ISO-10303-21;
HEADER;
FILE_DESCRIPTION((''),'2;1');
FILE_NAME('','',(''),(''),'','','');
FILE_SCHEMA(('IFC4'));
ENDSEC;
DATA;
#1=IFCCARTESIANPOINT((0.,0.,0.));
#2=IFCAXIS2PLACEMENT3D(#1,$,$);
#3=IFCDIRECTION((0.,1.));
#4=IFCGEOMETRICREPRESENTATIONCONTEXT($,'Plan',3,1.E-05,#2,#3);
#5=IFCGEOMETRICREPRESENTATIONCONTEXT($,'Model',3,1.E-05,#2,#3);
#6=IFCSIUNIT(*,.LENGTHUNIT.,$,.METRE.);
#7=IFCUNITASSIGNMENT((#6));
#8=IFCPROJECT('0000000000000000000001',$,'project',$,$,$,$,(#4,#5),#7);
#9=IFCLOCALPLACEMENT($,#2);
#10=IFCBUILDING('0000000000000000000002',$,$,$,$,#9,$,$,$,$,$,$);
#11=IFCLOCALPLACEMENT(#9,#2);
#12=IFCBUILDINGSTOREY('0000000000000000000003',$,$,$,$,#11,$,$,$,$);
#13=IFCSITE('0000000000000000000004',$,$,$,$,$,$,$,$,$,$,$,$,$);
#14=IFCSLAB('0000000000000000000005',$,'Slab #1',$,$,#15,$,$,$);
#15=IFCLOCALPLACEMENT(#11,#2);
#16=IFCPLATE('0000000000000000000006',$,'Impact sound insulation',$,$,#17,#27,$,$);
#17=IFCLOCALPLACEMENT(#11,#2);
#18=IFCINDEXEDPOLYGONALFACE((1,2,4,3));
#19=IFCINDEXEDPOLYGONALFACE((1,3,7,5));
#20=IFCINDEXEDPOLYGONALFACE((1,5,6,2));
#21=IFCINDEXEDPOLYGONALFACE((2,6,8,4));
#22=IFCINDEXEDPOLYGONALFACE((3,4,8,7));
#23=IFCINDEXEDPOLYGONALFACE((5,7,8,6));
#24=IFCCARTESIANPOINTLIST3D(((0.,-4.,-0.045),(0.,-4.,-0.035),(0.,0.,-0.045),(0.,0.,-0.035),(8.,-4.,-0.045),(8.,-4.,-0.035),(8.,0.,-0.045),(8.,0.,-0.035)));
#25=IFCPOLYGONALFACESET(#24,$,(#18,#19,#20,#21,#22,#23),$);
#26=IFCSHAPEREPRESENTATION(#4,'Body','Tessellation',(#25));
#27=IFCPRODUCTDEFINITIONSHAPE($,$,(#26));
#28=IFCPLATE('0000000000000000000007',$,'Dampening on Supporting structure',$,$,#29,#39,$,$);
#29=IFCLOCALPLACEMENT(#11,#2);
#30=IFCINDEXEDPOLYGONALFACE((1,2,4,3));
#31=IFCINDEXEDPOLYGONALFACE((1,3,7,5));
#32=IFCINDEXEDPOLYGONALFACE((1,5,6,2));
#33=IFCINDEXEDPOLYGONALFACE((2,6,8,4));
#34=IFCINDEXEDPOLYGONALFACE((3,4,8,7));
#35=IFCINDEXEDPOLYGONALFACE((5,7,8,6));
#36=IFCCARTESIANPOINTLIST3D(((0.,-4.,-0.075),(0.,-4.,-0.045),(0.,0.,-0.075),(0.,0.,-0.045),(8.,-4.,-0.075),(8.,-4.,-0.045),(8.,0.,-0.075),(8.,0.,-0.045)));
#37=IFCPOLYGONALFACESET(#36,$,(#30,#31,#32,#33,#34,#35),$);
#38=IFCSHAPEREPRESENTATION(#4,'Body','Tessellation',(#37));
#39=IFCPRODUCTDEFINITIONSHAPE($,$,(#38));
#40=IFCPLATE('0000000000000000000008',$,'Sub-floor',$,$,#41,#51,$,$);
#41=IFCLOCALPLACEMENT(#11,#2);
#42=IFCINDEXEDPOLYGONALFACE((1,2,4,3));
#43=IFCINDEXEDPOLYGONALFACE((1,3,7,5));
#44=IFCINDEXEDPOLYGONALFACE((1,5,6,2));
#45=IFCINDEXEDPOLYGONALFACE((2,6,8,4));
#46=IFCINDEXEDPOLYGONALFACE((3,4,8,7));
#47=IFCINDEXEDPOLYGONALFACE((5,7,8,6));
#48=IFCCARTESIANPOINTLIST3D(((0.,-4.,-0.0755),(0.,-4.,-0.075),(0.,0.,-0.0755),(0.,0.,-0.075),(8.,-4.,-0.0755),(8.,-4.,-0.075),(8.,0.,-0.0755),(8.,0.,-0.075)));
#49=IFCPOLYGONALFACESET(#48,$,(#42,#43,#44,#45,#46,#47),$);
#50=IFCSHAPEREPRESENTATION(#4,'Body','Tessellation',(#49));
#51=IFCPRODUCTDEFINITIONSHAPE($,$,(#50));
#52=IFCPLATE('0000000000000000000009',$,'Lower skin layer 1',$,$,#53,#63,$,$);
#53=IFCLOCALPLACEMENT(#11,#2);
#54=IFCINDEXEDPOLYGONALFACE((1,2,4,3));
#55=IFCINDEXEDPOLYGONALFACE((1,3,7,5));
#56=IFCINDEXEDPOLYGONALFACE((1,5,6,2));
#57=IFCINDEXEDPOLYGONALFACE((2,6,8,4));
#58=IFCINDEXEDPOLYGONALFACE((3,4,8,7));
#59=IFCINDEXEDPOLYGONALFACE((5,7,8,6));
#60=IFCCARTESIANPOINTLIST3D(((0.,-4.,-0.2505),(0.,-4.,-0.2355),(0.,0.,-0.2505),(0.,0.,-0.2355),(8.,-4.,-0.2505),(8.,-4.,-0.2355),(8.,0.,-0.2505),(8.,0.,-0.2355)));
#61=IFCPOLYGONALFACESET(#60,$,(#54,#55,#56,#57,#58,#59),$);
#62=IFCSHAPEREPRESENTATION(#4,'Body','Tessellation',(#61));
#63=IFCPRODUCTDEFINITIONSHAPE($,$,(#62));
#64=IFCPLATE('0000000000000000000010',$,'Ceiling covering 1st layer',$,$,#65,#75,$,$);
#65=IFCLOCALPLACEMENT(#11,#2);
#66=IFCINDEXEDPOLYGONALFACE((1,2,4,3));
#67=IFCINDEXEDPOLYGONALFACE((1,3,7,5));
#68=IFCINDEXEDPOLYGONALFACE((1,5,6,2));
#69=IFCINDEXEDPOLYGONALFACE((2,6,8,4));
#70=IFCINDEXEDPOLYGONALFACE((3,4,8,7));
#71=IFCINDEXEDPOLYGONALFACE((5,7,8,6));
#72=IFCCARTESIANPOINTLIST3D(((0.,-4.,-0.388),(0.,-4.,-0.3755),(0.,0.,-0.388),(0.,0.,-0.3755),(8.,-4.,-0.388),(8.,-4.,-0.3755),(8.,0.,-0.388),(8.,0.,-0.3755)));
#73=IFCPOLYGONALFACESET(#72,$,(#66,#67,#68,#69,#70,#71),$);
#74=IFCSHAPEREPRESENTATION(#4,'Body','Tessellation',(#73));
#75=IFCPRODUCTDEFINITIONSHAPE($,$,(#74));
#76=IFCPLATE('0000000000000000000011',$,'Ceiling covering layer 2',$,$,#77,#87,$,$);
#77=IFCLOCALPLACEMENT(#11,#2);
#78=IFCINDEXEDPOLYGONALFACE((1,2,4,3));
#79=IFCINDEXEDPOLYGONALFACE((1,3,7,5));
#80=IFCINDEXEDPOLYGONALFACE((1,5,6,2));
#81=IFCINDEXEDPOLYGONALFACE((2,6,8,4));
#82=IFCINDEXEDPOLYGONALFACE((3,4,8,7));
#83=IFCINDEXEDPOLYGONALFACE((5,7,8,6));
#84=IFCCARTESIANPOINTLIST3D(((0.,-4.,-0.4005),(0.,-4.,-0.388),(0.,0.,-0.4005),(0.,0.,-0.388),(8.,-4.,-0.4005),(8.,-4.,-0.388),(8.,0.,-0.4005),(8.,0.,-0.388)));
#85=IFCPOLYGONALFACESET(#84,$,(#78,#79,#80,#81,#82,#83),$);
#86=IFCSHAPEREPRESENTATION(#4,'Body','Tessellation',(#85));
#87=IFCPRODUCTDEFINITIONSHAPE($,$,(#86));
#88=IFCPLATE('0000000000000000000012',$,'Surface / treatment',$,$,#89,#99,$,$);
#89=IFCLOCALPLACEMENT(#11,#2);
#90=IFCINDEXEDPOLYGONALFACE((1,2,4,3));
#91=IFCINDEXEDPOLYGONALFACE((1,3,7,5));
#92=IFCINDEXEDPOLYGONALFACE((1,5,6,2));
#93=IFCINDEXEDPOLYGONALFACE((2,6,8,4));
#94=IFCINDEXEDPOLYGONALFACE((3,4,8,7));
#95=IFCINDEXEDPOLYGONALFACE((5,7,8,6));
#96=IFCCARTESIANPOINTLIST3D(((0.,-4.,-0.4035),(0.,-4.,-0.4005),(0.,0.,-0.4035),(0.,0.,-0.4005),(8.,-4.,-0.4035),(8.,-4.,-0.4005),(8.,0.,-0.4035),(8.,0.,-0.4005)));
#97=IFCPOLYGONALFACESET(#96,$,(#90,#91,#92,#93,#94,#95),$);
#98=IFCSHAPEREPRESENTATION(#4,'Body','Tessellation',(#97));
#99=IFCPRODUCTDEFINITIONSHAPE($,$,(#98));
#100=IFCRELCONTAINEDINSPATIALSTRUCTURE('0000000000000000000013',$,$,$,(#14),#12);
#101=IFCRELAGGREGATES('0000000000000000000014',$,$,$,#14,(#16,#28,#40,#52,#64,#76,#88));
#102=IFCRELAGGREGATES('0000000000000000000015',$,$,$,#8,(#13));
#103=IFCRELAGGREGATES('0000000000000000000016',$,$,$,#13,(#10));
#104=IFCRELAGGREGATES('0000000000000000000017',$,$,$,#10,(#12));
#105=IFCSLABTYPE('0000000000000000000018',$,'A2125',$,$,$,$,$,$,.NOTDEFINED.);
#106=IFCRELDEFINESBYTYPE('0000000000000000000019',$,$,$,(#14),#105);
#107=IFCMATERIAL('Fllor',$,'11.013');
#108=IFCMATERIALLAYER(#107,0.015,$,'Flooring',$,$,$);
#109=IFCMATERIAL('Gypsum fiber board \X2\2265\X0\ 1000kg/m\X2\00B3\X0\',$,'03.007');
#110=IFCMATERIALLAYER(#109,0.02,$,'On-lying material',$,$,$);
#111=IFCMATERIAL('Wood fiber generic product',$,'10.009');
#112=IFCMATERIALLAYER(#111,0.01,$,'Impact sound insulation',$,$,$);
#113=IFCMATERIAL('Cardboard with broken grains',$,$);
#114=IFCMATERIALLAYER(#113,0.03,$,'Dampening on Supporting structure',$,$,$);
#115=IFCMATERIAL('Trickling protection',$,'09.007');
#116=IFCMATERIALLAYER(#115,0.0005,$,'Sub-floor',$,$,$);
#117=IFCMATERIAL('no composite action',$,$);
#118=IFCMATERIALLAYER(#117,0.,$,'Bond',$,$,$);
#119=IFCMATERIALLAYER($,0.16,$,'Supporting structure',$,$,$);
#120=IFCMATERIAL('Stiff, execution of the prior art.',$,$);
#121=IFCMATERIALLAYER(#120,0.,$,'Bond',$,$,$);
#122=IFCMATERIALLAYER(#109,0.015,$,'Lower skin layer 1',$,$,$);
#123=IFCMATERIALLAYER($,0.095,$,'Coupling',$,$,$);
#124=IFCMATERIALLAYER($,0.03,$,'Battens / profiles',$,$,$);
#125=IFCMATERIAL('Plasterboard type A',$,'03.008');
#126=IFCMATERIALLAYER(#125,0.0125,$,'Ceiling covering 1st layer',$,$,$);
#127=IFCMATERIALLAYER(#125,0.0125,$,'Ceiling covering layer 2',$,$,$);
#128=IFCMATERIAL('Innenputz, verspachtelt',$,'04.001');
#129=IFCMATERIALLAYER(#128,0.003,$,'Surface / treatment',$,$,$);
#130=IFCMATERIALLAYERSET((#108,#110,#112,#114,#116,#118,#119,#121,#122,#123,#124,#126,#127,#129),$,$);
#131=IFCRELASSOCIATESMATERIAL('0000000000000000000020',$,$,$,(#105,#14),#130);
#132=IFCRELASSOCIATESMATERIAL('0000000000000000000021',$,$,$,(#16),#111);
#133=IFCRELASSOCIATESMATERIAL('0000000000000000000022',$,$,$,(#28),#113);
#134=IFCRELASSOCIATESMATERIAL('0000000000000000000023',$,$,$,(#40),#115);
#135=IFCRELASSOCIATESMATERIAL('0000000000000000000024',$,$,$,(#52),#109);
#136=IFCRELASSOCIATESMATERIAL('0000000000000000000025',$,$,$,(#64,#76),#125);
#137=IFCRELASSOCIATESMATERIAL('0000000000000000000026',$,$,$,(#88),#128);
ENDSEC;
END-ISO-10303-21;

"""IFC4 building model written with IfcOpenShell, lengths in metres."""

from ifc_helpers import new_model, si_unit, direction, frame, frame_2d, origin, place, context, project, spatial, rectangle, extrude, material, layer, layer_set, type_object, element, aggregate, save


model = new_model("IFC4")

# Units and contexts
plan_context = context("Plan", 3, precision=1e-05, world=origin(), true_north=direction((0.0, 1.0)))
model_context = context("Model", 3, precision=1e-05, world=origin(), true_north=direction((0.0, 1.0)))
ifc_project = project(units=[si_unit("LENGTHUNIT", "METRE")], contexts=[plan_context, model_context])

# Site, building, storey
site = spatial("IfcSite", under=ifc_project)
building_placement = place(None, origin())
building = spatial("IfcBuilding", under=site, at=building_placement)
storey_placement = place(building_placement, origin())
storey = spatial("IfcBuildingStorey", under=building, at=storey_placement)

# Slab, plates
ifc_material_1 = material(Name="Fllor", Category="11.013")
ifc_layer_1 = layer(ifc_material_1, 0.015, Name="Flooring")
ifc_material_2 = material(Name="Gypsum fiber board ≥ 1000kg/m³", Category="03.007")
ifc_layer_2 = layer(ifc_material_2, 0.02, Name="On-lying material")
ifc_material_3 = material(Name="Wood fiber generic product", Category="10.009")
ifc_layer_3 = layer(ifc_material_3, 0.01, Name="Impact sound insulation")
ifc_material_4 = material(Name="Cardboard with broken grains")
ifc_layer_4 = layer(ifc_material_4, 0.03, Name="Dampening on Supporting structure")
ifc_material_5 = material(Name="Trickling protection", Category="09.007")
ifc_layer_5 = layer(ifc_material_5, 0.0005, Name="Sub-floor")
ifc_material_6 = material(Name="no composite action")
ifc_layer_6 = layer(ifc_material_6, 0.0, Name="Bond")
ifc_layer_7 = layer(None, 0.16, Name="Supporting structure")
ifc_material_7 = material(Name="Stiff, execution of the prior art.")
ifc_layer_8 = layer(ifc_material_7, 0.0, Name="Bond")
ifc_layer_9 = layer(ifc_material_2, 0.015, Name="Lower skin layer 1")
ifc_layer_10 = layer(None, 0.095, Name="Coupling")
ifc_layer_11 = layer(None, 0.03, Name="Battens / profiles")
ifc_material_8 = material(Name="Plasterboard type A", Category="03.008")
ifc_layer_12 = layer(ifc_material_8, 0.0125, Name="Ceiling covering 1st layer")
ifc_layer_13 = layer(ifc_material_8, 0.0125, Name="Ceiling covering layer 2")
ifc_material_9 = material(Name="Innenputz, verspachtelt", Category="04.001")
ifc_layer_14 = layer(ifc_material_9, 0.003, Name="Surface / treatment")
ifc_layer_set = layer_set([ifc_layer_1, ifc_layer_2, ifc_layer_3, ifc_layer_4, ifc_layer_5, ifc_layer_6, ifc_layer_7, ifc_layer_8, ifc_layer_9, ifc_layer_10, ifc_layer_11, ifc_layer_12, ifc_layer_13, ifc_layer_14])
slab_type = type_object("IfcSlabType", Name="A2125", PredefinedType="NOTDEFINED", material=ifc_layer_set)
slab_placement = place(None, frame((0.0, 0.0, 0.0), z_axis=(0.0, 0.0, -1.0), x_axis=(1.0, 0.0, 0.0)))
slab = element("IfcSlab", 1, at=slab_placement, inside=storey, type_object=slab_type, material=ifc_layer_set, Name="Slab #1")
plate_1_placement = place(slab_placement, origin())
plate_1 = element("IfcPlate", 2, at=plate_1_placement, material=ifc_material_3, Name="Impact sound insulation", context=plan_context, shape_type="SweptSolid", body=[
    extrude(rectangle(XDim=8.0, YDim=4.0, at=frame_2d((4.0, 2.0), x_axis=(1.0, 0.0))), frame((0.0, 0.0, 0.035), z_axis=(0.0, 0.0, 1.0), x_axis=(1.0, 0.0, 0.0)), (0.0, 0.0, 1.0), 0.01),
])
plate_2_placement = place(slab_placement, origin())
plate_2 = element("IfcPlate", 3, at=plate_2_placement, material=ifc_material_4, Name="Dampening on Supporting structure", context=plan_context, shape_type="SweptSolid", body=[
    extrude(rectangle(XDim=8.0, YDim=4.0, at=frame_2d((4.0, 2.0), x_axis=(1.0, 0.0))), frame((0.0, 0.0, 0.045), z_axis=(0.0, 0.0, 1.0), x_axis=(1.0, 0.0, 0.0)), (0.0, 0.0, 1.0), 0.03),
])
plate_3_placement = place(slab_placement, origin())
plate_3 = element("IfcPlate", 4, at=plate_3_placement, material=ifc_material_5, Name="Sub-floor", context=plan_context, shape_type="SweptSolid", body=[
    extrude(rectangle(XDim=8.0, YDim=4.0, at=frame_2d((4.0, 2.0), x_axis=(1.0, 0.0))), frame((0.0, 0.0, 0.075), z_axis=(0.0, 0.0, 1.0), x_axis=(1.0, 0.0, 0.0)), (0.0, 0.0, 1.0), 0.0005),
])
plate_4_placement = place(slab_placement, origin())
plate_4 = element("IfcPlate", 5, at=plate_4_placement, material=ifc_material_2, Name="Lower skin layer 1", context=plan_context, shape_type="SweptSolid", body=[
    extrude(rectangle(XDim=8.0, YDim=4.0, at=frame_2d((4.0, 2.0), x_axis=(1.0, 0.0))), frame((0.0, 0.0, 0.2355), z_axis=(0.0, 0.0, 1.0), x_axis=(1.0, 0.0, 0.0)), (0.0, 0.0, 1.0), 0.015),
])
plate_5_placement = place(slab_placement, origin())
plate_5 = element("IfcPlate", 6, at=plate_5_placement, material=ifc_material_8, Name="Ceiling covering 1st layer", context=plan_context, shape_type="SweptSolid", body=[
    extrude(rectangle(XDim=8.0, YDim=4.0, at=frame_2d((4.0, 2.0), x_axis=(1.0, 0.0))), frame((0.0, 0.0, 0.3755), z_axis=(0.0, 0.0, 1.0), x_axis=(1.0, 0.0, 0.0)), (0.0, 0.0, 1.0), 0.0125),
])
plate_6_placement = place(slab_placement, origin())
plate_6 = element("IfcPlate", 7, at=plate_6_placement, material=ifc_material_8, Name="Ceiling covering layer 2", context=plan_context, shape_type="SweptSolid", body=[
    extrude(rectangle(XDim=8.0, YDim=4.0, at=frame_2d((4.0, 2.0), x_axis=(1.0, 0.0))), frame((0.0, 0.0, 0.388), z_axis=(0.0, 0.0, 1.0), x_axis=(1.0, 0.0, 0.0)), (0.0, 0.0, 1.0), 0.0125),
])
plate_7_placement = place(slab_placement, origin())
plate_7 = element("IfcPlate", 8, at=plate_7_placement, material=ifc_material_9, Name="Surface / treatment", context=plan_context, shape_type="SweptSolid", body=[
    extrude(rectangle(XDim=8.0, YDim=4.0, at=frame_2d((4.0, 2.0), x_axis=(1.0, 0.0))), frame((0.0, 0.0, 0.4005), z_axis=(0.0, 0.0, 1.0), x_axis=(1.0, 0.0, 0.0)), (0.0, 0.0, 1.0), 0.003),
])
aggregate(slab, [plate_1, plate_2, plate_3, plate_4, plate_5, plate_6, plate_7])

save(model, "model.ifc")
